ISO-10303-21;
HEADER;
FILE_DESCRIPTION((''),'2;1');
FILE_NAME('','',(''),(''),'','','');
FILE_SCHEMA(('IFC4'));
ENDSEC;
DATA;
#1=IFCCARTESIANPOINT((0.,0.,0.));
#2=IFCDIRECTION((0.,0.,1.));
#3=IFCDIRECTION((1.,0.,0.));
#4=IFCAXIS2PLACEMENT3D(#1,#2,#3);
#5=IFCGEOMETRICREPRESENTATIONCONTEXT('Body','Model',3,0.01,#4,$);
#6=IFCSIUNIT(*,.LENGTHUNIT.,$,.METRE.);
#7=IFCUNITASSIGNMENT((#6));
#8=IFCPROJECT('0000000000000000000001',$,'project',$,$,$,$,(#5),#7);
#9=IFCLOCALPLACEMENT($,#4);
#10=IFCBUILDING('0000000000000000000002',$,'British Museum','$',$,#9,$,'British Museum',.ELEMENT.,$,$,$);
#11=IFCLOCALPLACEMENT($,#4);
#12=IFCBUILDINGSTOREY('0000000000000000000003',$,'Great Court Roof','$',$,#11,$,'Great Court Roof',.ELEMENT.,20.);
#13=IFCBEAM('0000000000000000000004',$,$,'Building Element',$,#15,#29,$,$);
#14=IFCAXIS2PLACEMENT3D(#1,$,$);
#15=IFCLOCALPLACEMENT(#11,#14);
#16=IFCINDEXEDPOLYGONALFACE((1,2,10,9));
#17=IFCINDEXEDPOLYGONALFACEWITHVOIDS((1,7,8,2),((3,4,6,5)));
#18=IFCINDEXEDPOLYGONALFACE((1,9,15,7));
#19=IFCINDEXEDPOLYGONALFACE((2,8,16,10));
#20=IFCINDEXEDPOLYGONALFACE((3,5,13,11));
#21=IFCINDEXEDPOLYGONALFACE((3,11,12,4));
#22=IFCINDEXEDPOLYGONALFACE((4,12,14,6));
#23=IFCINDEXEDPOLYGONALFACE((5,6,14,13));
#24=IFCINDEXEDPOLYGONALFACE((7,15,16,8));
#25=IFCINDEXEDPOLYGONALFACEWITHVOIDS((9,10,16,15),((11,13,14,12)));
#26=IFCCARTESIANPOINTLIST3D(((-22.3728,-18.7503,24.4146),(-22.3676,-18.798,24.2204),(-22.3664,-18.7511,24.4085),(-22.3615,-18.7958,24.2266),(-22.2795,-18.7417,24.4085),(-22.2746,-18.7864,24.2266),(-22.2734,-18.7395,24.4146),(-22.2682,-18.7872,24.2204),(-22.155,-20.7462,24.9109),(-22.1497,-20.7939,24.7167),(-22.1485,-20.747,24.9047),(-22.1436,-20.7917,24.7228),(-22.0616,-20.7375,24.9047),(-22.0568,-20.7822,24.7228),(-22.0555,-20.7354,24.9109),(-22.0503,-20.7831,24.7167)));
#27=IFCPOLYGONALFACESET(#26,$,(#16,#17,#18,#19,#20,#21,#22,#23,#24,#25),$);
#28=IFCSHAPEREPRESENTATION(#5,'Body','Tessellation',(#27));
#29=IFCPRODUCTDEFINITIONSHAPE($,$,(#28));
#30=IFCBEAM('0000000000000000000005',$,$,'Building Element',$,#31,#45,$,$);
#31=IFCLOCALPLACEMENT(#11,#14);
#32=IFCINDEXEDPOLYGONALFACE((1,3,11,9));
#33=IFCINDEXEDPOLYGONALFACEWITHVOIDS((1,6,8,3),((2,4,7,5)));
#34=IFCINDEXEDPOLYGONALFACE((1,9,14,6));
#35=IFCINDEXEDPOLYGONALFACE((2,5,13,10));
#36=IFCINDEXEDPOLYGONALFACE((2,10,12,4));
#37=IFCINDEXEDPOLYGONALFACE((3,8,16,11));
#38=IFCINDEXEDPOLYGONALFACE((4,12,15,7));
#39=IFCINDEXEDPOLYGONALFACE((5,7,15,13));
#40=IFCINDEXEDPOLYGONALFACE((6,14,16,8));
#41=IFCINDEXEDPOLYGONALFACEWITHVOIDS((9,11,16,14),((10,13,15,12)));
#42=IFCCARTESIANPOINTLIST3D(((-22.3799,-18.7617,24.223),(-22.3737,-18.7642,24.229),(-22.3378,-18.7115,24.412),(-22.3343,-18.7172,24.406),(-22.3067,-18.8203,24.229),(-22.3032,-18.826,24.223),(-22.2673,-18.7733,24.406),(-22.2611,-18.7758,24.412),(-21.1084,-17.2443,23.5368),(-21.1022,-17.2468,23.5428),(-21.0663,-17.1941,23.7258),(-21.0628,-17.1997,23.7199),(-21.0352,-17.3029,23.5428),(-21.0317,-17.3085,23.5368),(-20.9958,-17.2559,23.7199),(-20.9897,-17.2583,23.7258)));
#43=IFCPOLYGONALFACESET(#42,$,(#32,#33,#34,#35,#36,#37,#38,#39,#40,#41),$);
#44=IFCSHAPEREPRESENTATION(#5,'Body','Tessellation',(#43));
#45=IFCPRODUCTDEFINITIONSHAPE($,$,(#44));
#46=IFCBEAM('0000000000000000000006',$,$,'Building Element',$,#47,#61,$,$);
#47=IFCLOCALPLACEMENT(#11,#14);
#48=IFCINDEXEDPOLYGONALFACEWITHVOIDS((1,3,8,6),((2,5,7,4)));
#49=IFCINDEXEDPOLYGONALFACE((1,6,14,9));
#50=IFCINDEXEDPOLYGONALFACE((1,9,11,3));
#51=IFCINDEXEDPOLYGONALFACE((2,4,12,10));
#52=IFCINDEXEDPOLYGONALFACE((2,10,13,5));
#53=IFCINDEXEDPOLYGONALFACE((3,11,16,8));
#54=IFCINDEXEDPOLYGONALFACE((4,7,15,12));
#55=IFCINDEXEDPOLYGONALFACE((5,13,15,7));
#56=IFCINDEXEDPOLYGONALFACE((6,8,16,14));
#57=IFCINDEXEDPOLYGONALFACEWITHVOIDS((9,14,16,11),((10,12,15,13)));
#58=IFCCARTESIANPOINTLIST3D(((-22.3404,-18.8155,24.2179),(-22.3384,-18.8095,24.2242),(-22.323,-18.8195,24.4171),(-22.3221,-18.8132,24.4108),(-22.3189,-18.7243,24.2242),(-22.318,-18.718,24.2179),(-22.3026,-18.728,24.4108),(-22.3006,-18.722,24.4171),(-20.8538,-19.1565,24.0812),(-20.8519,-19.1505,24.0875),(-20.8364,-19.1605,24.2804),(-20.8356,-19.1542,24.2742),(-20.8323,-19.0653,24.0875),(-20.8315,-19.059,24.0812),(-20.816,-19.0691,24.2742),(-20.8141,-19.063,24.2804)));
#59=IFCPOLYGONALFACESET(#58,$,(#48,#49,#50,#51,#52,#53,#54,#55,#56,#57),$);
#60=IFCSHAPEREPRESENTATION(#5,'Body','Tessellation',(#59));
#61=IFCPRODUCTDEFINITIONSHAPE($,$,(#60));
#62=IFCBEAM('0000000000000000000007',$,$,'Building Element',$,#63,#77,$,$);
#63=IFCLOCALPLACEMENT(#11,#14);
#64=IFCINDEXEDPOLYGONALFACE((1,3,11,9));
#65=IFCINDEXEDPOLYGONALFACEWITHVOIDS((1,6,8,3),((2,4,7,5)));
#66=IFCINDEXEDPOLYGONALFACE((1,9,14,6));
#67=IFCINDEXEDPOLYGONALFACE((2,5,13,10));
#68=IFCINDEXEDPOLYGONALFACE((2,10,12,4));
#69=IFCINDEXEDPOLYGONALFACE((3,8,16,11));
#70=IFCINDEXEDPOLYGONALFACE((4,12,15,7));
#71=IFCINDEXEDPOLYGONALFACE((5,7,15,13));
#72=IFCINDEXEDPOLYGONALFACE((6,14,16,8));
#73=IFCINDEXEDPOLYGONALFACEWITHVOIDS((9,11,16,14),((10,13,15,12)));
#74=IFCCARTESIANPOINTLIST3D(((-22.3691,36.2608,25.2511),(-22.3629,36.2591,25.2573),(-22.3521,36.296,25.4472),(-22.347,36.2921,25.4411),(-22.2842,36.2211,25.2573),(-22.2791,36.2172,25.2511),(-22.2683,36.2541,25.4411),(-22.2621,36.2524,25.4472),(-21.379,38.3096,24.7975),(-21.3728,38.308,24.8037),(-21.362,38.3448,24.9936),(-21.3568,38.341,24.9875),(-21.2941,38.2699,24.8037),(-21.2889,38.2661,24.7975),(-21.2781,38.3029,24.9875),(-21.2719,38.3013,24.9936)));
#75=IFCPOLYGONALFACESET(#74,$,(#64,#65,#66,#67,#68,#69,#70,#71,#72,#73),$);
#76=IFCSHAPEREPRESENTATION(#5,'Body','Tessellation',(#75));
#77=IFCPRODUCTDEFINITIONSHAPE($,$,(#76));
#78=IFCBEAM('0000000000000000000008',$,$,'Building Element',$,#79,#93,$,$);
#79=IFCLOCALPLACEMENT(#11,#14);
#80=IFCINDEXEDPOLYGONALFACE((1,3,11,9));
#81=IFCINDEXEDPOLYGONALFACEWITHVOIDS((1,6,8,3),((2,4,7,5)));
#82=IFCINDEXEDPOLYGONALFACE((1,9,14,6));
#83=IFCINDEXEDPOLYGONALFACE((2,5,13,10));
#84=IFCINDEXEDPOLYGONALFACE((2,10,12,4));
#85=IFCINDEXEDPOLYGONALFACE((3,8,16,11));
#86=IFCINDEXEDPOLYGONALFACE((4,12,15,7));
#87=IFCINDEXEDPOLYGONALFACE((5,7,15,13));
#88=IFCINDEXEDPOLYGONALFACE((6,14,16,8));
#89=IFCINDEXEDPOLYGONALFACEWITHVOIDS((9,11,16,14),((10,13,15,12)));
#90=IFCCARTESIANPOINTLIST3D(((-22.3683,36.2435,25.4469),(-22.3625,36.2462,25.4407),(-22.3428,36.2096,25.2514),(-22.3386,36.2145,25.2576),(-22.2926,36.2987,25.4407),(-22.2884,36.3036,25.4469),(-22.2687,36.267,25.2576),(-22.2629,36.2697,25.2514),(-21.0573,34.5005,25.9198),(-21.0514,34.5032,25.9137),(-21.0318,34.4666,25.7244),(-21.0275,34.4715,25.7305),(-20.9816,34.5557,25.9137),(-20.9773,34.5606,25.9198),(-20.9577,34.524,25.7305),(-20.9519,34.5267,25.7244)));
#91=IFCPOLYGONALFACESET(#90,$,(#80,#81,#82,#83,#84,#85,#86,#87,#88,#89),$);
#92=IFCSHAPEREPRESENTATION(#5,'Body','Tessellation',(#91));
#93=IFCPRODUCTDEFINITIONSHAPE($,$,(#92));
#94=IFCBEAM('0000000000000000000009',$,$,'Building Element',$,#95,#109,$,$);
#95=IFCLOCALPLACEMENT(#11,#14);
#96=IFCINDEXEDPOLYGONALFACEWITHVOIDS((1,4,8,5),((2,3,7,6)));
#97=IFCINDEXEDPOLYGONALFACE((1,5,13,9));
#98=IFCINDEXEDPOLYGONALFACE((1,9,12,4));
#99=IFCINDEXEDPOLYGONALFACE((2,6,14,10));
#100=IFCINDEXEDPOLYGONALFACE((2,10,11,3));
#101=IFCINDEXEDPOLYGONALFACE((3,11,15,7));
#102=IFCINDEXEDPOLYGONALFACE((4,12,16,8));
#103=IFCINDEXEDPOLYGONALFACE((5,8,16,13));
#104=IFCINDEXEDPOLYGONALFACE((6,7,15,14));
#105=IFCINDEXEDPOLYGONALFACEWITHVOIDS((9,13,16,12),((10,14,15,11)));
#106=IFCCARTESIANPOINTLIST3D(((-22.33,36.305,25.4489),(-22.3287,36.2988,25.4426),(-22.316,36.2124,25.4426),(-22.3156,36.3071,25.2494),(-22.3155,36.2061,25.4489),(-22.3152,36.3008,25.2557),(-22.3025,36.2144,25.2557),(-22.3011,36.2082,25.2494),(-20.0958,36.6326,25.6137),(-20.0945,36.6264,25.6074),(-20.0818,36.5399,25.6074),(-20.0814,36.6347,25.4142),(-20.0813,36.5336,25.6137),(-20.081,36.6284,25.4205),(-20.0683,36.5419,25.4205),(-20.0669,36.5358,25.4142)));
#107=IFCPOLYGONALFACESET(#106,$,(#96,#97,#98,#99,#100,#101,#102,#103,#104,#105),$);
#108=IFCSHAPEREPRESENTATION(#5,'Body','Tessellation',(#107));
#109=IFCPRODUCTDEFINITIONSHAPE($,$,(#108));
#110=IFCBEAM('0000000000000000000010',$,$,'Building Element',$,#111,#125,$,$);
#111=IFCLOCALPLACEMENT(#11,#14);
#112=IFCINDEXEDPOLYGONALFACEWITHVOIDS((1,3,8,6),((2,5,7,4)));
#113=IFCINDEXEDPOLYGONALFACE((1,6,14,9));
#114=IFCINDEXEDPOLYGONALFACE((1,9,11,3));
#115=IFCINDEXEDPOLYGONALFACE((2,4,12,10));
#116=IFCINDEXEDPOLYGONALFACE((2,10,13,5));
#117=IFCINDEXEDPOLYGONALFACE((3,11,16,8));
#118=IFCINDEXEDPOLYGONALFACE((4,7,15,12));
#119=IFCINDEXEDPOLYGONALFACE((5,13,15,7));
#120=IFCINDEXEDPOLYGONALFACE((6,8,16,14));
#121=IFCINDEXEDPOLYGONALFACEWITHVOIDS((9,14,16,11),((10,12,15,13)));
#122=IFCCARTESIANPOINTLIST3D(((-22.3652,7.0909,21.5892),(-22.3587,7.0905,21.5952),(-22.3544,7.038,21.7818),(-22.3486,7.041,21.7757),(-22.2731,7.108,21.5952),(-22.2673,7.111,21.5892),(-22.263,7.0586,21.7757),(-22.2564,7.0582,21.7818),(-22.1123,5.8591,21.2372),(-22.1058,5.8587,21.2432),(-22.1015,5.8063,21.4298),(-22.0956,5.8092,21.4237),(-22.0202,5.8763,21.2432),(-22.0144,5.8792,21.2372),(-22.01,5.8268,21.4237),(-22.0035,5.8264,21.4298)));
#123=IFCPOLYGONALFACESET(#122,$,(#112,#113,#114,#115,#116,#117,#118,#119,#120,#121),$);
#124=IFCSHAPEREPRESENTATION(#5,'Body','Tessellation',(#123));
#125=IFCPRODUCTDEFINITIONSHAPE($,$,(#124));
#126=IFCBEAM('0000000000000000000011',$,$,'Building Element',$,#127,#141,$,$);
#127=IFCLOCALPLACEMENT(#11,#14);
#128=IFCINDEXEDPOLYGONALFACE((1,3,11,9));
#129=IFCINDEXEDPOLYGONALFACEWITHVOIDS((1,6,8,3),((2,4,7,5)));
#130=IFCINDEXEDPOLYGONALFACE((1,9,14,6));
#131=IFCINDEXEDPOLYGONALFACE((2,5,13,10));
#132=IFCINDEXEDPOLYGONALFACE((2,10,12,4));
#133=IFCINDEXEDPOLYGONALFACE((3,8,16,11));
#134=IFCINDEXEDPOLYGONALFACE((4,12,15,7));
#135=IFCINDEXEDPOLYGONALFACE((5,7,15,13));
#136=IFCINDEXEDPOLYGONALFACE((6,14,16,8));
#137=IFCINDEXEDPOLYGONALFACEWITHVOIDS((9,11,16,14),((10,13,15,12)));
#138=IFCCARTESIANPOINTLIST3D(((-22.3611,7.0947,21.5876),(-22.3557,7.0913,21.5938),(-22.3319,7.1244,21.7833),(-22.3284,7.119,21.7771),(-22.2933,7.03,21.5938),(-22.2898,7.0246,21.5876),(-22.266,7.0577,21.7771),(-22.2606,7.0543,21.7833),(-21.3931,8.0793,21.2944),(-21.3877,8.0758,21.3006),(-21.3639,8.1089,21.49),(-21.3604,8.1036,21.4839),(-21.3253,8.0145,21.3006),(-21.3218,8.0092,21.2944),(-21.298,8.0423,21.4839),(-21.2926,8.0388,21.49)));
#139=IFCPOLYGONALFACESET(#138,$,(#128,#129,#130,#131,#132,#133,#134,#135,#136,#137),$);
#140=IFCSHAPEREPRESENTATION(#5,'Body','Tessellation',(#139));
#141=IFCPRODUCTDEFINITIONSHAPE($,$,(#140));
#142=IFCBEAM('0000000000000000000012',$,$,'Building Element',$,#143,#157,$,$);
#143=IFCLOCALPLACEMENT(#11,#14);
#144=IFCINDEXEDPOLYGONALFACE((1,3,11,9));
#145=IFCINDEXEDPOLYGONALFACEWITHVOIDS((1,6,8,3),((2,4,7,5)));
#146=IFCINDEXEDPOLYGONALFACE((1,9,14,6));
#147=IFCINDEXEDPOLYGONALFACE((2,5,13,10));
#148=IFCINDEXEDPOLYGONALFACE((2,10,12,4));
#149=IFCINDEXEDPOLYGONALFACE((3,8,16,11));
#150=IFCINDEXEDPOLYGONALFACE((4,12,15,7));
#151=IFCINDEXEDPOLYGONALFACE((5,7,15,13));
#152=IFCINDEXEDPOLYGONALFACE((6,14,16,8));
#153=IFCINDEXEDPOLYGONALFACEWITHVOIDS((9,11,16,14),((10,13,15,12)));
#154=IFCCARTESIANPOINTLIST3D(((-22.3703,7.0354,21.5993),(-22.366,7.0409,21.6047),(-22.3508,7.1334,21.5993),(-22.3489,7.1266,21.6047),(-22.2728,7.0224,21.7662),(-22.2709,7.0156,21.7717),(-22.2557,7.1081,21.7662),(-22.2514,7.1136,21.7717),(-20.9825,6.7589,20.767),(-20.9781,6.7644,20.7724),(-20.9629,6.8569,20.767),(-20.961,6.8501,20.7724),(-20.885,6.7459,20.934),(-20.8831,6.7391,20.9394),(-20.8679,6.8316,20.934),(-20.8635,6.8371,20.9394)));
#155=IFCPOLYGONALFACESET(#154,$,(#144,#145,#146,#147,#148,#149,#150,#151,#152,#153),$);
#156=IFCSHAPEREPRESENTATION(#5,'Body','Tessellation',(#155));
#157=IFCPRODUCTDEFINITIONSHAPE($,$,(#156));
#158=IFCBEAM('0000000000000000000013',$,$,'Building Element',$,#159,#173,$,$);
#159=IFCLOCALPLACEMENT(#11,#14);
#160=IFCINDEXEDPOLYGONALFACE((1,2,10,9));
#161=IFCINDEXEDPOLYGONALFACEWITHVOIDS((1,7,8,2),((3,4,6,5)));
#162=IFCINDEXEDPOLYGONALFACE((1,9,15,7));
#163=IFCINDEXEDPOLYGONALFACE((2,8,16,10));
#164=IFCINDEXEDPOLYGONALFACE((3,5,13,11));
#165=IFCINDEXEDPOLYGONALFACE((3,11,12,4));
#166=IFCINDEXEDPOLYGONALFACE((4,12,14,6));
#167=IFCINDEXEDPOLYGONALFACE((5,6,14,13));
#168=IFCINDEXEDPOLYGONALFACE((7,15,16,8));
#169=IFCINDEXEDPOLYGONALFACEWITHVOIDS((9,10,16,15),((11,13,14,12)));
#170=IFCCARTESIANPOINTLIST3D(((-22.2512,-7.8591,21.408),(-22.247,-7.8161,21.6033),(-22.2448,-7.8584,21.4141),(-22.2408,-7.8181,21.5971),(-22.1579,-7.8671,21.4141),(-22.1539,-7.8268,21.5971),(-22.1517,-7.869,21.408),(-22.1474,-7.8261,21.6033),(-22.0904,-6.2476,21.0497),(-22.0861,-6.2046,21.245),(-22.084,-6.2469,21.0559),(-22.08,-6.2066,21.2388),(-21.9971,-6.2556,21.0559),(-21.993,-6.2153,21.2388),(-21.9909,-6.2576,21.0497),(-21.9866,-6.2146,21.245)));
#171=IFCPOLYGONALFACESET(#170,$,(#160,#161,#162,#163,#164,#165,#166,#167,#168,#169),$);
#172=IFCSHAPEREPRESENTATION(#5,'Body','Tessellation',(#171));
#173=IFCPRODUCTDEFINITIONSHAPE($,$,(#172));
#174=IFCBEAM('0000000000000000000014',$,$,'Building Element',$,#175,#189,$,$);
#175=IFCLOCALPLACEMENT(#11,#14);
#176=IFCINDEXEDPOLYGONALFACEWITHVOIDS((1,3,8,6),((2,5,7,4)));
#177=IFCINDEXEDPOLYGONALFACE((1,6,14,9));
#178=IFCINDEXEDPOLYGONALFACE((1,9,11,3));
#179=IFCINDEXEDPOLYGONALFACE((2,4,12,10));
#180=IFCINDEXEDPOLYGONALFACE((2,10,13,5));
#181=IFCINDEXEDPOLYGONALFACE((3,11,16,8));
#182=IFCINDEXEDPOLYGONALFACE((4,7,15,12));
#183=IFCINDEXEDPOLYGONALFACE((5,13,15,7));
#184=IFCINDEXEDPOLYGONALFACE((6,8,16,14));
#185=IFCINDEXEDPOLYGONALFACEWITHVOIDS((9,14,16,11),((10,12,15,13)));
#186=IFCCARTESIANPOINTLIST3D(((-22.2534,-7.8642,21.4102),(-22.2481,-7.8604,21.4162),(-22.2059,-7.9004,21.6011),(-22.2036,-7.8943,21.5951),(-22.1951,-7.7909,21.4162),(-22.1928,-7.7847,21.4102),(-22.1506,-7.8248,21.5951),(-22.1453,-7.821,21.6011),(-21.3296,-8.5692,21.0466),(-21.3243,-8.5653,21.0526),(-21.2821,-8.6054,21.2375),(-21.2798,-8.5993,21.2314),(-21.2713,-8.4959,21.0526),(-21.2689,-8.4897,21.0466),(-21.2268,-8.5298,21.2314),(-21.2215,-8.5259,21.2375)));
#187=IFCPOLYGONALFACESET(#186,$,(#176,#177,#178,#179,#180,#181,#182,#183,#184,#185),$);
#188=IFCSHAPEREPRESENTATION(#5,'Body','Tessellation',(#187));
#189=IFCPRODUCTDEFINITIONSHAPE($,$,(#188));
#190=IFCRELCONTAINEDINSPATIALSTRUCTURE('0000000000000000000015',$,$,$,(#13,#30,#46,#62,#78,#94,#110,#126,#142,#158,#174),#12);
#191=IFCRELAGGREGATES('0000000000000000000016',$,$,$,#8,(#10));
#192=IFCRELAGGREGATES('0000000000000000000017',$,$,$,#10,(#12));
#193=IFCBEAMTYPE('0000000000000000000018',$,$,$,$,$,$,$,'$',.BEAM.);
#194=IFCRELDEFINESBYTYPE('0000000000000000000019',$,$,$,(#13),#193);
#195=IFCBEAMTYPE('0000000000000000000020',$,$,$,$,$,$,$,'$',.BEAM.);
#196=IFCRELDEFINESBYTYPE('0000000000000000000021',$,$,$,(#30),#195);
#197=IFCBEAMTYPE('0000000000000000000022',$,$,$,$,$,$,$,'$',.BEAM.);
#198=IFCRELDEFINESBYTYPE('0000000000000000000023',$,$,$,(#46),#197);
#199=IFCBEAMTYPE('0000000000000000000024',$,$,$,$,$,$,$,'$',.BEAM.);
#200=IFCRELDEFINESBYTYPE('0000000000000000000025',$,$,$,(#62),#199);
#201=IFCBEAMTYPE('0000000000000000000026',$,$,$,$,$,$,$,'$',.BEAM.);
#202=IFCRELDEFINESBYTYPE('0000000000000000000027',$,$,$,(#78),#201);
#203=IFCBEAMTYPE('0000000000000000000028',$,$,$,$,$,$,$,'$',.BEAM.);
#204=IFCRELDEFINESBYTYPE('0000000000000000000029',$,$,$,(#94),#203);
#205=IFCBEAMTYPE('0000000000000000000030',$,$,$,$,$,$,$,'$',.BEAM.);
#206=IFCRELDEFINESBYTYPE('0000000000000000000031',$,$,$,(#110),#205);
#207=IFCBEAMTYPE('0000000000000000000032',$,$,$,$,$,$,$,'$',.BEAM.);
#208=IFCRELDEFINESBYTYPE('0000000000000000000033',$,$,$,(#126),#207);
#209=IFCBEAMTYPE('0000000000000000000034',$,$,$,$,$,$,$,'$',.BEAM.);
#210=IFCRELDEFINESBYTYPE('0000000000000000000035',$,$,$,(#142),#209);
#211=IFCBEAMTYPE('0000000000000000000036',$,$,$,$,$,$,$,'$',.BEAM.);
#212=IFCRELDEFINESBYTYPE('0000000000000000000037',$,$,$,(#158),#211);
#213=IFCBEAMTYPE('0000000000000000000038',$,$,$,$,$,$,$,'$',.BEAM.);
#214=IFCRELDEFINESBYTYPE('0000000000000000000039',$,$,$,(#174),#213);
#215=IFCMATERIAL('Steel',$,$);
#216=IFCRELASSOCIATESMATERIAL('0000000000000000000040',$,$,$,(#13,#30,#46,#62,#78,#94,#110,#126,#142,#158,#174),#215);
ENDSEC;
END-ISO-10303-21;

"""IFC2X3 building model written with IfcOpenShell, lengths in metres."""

from ifc_helpers import new_model, si_unit, frame, origin_with_axes, origin_2d, place, context, project, spatial, hollow_rectangle, extrude, material, type_object, element, save


model = new_model("IFC2X3")

# Units and contexts
model_context = context("Model", 3, precision=0.01, world=origin_with_axes(), identifier="Body")
ifc_project = project(units=[si_unit("LENGTHUNIT", "METRE")], contexts=[model_context])

# Building, storey
building_placement = place(None, origin_with_axes())
building = spatial("IfcBuilding", under=ifc_project, at=building_placement, Name="British Museum", Description="$", LongName="British Museum", CompositionType="ELEMENT")
storey_placement = place(None, origin_with_axes())
storey = spatial("IfcBuildingStorey", under=building, at=storey_placement, Name="Great Court Roof", Description="$", LongName="Great Court Roof", CompositionType="ELEMENT", Elevation=20.0)

# Beams
ifc_material = material(Name="Steel")
beam_type_1 = type_object("IfcBeamType", ElementType="$", PredefinedType="BEAM")
beam_1_placement = place(None, origin_with_axes())
element("IfcBeam", 1, at=beam_1_placement, inside=storey, type_object=beam_type_1, material=ifc_material, Description="Building Element", context=model_context, shape_type="SweptSolid", body=[
    extrude(hollow_rectangle(XDim=0.1, YDim=0.2, WallThickness=0.0063, InnerFilletRadius=0.0, OuterFilletRadius=0.0, at=origin_2d()), frame((-22.3205, -18.7688, 24.3175), z_axis=(0.105338, -0.965053, 0.239953), x_axis=(0.994096, 0.108508, 0.0)), (0.0, 0.0, 1.0), 2.0682),
])
beam_type_2 = type_object("IfcBeamType", ElementType="$", PredefinedType="BEAM")
beam_2_placement = place(None, origin_with_axes())
element("IfcBeam", 2, at=beam_2_placement, inside=storey, type_object=beam_type_2, material=ifc_material, Description="Building Element", context=model_context, shape_type="SweptSolid", body=[
    extrude(hollow_rectangle(XDim=0.1, YDim=0.2, WallThickness=0.0063, InnerFilletRadius=0.0, OuterFilletRadius=0.0, at=origin_2d()), frame((-22.3205, -18.7688, 24.3175), z_axis=(0.606835, 0.724221, -0.327498), x_axis=(-0.766491, 0.642254, 0.0)), (0.0, 0.0, 1.0), 2.0953),
])
beam_type_3 = type_object("IfcBeamType", ElementType="$", PredefinedType="BEAM")
beam_3_placement = place(None, origin_with_axes())
element("IfcBeam", 3, at=beam_3_placement, inside=storey, type_object=beam_type_3, material=ifc_material, Description="Building Element", context=model_context, shape_type="SweptSolid", body=[
    extrude(hollow_rectangle(XDim=0.1, YDim=0.2, WallThickness=0.0063, InnerFilletRadius=0.0, OuterFilletRadius=0.0, at=origin_2d()), frame((-22.3205, -18.7688, 24.3175), z_axis=(0.970792, -0.222702, -0.08926), x_axis=(0.223595, 0.974682, 0.0)), (0.0, 0.0, 1.0), 1.5313),
])
beam_type_4 = type_object("IfcBeamType", ElementType="$", PredefinedType="BEAM")
beam_4_placement = place(None, origin_with_axes())
element("IfcBeam", 4, at=beam_4_placement, inside=storey, type_object=beam_type_4, material=ifc_material, Description="Building Element", context=model_context, shape_type="SweptSolid", body=[
    extrude(hollow_rectangle(XDim=0.1, YDim=0.2, WallThickness=0.0063, InnerFilletRadius=0.0, OuterFilletRadius=0.0, at=origin_2d()), frame((-22.3156, 36.2566, 25.3492), z_axis=(0.426728, 0.882998, -0.195491), x_axis=(-0.900371, 0.435124, 0.0)), (0.0, 0.0, 1.0), 2.3203),
])
beam_type_5 = type_object("IfcBeamType", ElementType="$", PredefinedType="BEAM")
beam_5_placement = place(None, origin_with_axes())
element("IfcBeam", 5, at=beam_5_placement, inside=storey, type_object=beam_type_5, material=ifc_material, Description="Building Element", context=model_context, shape_type="SweptSolid", body=[
    extrude(hollow_rectangle(XDim=0.1, YDim=0.2, WallThickness=0.0063, InnerFilletRadius=0.0, OuterFilletRadius=0.0, at=origin_2d()), frame((-22.3156, 36.2566, 25.3492), z_axis=(0.587459, -0.781015, 0.211914), x_axis=(0.799165, 0.601112, 0.0)), (0.0, 0.0, 1.0), 2.2317),
])
beam_type_6 = type_object("IfcBeamType", ElementType="$", PredefinedType="BEAM")
beam_6_placement = place(None, origin_with_axes())
element("IfcBeam", 6, at=beam_6_placement, inside=storey, type_object=beam_type_6, material=ifc_material, Description="Building Element", context=model_context, shape_type="SweptSolid", body=[
    extrude(hollow_rectangle(XDim=0.1, YDim=0.2, WallThickness=0.0063, InnerFilletRadius=0.0, OuterFilletRadius=0.0, at=origin_2d()), frame((-22.3156, 36.2566, 25.3492), z_axis=(0.986798, 0.144683, 0.072776), x_axis=(-0.145068, 0.989422, 0.0)), (0.0, 0.0, 1.0), 2.2641),
])
beam_type_7 = type_object("IfcBeamType", ElementType="$", PredefinedType="BEAM")
beam_7_placement = place(None, origin_with_axes())
element("IfcBeam", 7, at=beam_7_placement, inside=storey, type_object=beam_type_7, material=ifc_material, Description="Building Element", context=model_context, shape_type="SweptSolid", body=[
    extrude(hollow_rectangle(XDim=0.1, YDim=0.2, WallThickness=0.0063, InnerFilletRadius=0.0, OuterFilletRadius=0.0, at=origin_2d()), frame((-22.3108, 7.0745, 21.6855), z_axis=(0.193706, -0.943296, -0.269575), x_axis=(0.97956, 0.201153, 0.0)), (0.0, 0.0, 1.0), 1.3058),
])
beam_type_8 = type_object("IfcBeamType", ElementType="$", PredefinedType="BEAM")
beam_8_placement = place(None, origin_with_axes())
element("IfcBeam", 8, at=beam_8_placement, inside=storey, type_object=beam_type_8, material=ifc_material, Description="Building Element", context=model_context, shape_type="SweptSolid", body=[
    extrude(hollow_rectangle(XDim=0.1, YDim=0.2, WallThickness=0.0063, InnerFilletRadius=0.0, OuterFilletRadius=0.0, at=origin_2d()), frame((-22.3108, 7.0745, 21.6855), z_axis=(0.685793, 0.697517, -0.207746), x_axis=(-0.713074, 0.701088, 0.0)), (0.0, 0.0, 1.0), 1.4115),
])
beam_type_9 = type_object("IfcBeamType", ElementType="$", PredefinedType="BEAM")
beam_9_placement = place(None, origin_with_axes())
element("IfcBeam", 9, at=beam_9_placement, inside=storey, type_object=beam_type_9, material=ifc_material, Description="Building Element", context=model_context, shape_type="SweptSolid", body=[
    extrude(hollow_rectangle(XDim=0.1, YDim=0.2, WallThickness=0.0063, InnerFilletRadius=0.0, OuterFilletRadius=0.0, at=origin_2d()), frame((-22.3108, 7.0745, 21.6855), z_axis=(0.845362, -0.168423, -0.506949), x_axis=(0.195392, 0.980725, 0.0)), (0.0, 0.0, 1.0), 1.6417),
])
beam_type_10 = type_object("IfcBeamType", ElementType="$", PredefinedType="BEAM")
beam_10_placement = place(None, origin_with_axes())
element("IfcBeam", 10, at=beam_10_placement, inside=storey, type_object=beam_type_10, material=ifc_material, Description="Building Element", context=model_context, shape_type="SweptSolid", body=[
    extrude(hollow_rectangle(XDim=0.1, YDim=0.2, WallThickness=0.0063, InnerFilletRadius=0.0, OuterFilletRadius=0.0, at=origin_2d()), frame((-22.1993, -7.8426, 21.5056), z_axis=(0.09695, 0.971566, -0.216012), x_axis=(-0.995058, 0.099294, 0.0)), (0.0, 0.0, 1.0), 1.6586),
])
beam_type_11 = type_object("IfcBeamType", ElementType="$", PredefinedType="BEAM")
beam_11_placement = place(None, origin_with_axes())
element("IfcBeam", 11, at=beam_11_placement, inside=storey, type_object=beam_type_11, material=ifc_material, Description="Building Element", context=model_context, shape_type="SweptSolid", body=[
    extrude(hollow_rectangle(XDim=0.1, YDim=0.2, WallThickness=0.0063, InnerFilletRadius=0.0, OuterFilletRadius=0.0, at=origin_2d()), frame((-22.1993, -7.8426, 21.5056), z_axis=(0.758693, -0.578976, -0.298617), x_axis=(0.606656, 0.794964, 0.0)), (0.0, 0.0, 1.0), 1.2176),
])

save(model, "model.ifc")
